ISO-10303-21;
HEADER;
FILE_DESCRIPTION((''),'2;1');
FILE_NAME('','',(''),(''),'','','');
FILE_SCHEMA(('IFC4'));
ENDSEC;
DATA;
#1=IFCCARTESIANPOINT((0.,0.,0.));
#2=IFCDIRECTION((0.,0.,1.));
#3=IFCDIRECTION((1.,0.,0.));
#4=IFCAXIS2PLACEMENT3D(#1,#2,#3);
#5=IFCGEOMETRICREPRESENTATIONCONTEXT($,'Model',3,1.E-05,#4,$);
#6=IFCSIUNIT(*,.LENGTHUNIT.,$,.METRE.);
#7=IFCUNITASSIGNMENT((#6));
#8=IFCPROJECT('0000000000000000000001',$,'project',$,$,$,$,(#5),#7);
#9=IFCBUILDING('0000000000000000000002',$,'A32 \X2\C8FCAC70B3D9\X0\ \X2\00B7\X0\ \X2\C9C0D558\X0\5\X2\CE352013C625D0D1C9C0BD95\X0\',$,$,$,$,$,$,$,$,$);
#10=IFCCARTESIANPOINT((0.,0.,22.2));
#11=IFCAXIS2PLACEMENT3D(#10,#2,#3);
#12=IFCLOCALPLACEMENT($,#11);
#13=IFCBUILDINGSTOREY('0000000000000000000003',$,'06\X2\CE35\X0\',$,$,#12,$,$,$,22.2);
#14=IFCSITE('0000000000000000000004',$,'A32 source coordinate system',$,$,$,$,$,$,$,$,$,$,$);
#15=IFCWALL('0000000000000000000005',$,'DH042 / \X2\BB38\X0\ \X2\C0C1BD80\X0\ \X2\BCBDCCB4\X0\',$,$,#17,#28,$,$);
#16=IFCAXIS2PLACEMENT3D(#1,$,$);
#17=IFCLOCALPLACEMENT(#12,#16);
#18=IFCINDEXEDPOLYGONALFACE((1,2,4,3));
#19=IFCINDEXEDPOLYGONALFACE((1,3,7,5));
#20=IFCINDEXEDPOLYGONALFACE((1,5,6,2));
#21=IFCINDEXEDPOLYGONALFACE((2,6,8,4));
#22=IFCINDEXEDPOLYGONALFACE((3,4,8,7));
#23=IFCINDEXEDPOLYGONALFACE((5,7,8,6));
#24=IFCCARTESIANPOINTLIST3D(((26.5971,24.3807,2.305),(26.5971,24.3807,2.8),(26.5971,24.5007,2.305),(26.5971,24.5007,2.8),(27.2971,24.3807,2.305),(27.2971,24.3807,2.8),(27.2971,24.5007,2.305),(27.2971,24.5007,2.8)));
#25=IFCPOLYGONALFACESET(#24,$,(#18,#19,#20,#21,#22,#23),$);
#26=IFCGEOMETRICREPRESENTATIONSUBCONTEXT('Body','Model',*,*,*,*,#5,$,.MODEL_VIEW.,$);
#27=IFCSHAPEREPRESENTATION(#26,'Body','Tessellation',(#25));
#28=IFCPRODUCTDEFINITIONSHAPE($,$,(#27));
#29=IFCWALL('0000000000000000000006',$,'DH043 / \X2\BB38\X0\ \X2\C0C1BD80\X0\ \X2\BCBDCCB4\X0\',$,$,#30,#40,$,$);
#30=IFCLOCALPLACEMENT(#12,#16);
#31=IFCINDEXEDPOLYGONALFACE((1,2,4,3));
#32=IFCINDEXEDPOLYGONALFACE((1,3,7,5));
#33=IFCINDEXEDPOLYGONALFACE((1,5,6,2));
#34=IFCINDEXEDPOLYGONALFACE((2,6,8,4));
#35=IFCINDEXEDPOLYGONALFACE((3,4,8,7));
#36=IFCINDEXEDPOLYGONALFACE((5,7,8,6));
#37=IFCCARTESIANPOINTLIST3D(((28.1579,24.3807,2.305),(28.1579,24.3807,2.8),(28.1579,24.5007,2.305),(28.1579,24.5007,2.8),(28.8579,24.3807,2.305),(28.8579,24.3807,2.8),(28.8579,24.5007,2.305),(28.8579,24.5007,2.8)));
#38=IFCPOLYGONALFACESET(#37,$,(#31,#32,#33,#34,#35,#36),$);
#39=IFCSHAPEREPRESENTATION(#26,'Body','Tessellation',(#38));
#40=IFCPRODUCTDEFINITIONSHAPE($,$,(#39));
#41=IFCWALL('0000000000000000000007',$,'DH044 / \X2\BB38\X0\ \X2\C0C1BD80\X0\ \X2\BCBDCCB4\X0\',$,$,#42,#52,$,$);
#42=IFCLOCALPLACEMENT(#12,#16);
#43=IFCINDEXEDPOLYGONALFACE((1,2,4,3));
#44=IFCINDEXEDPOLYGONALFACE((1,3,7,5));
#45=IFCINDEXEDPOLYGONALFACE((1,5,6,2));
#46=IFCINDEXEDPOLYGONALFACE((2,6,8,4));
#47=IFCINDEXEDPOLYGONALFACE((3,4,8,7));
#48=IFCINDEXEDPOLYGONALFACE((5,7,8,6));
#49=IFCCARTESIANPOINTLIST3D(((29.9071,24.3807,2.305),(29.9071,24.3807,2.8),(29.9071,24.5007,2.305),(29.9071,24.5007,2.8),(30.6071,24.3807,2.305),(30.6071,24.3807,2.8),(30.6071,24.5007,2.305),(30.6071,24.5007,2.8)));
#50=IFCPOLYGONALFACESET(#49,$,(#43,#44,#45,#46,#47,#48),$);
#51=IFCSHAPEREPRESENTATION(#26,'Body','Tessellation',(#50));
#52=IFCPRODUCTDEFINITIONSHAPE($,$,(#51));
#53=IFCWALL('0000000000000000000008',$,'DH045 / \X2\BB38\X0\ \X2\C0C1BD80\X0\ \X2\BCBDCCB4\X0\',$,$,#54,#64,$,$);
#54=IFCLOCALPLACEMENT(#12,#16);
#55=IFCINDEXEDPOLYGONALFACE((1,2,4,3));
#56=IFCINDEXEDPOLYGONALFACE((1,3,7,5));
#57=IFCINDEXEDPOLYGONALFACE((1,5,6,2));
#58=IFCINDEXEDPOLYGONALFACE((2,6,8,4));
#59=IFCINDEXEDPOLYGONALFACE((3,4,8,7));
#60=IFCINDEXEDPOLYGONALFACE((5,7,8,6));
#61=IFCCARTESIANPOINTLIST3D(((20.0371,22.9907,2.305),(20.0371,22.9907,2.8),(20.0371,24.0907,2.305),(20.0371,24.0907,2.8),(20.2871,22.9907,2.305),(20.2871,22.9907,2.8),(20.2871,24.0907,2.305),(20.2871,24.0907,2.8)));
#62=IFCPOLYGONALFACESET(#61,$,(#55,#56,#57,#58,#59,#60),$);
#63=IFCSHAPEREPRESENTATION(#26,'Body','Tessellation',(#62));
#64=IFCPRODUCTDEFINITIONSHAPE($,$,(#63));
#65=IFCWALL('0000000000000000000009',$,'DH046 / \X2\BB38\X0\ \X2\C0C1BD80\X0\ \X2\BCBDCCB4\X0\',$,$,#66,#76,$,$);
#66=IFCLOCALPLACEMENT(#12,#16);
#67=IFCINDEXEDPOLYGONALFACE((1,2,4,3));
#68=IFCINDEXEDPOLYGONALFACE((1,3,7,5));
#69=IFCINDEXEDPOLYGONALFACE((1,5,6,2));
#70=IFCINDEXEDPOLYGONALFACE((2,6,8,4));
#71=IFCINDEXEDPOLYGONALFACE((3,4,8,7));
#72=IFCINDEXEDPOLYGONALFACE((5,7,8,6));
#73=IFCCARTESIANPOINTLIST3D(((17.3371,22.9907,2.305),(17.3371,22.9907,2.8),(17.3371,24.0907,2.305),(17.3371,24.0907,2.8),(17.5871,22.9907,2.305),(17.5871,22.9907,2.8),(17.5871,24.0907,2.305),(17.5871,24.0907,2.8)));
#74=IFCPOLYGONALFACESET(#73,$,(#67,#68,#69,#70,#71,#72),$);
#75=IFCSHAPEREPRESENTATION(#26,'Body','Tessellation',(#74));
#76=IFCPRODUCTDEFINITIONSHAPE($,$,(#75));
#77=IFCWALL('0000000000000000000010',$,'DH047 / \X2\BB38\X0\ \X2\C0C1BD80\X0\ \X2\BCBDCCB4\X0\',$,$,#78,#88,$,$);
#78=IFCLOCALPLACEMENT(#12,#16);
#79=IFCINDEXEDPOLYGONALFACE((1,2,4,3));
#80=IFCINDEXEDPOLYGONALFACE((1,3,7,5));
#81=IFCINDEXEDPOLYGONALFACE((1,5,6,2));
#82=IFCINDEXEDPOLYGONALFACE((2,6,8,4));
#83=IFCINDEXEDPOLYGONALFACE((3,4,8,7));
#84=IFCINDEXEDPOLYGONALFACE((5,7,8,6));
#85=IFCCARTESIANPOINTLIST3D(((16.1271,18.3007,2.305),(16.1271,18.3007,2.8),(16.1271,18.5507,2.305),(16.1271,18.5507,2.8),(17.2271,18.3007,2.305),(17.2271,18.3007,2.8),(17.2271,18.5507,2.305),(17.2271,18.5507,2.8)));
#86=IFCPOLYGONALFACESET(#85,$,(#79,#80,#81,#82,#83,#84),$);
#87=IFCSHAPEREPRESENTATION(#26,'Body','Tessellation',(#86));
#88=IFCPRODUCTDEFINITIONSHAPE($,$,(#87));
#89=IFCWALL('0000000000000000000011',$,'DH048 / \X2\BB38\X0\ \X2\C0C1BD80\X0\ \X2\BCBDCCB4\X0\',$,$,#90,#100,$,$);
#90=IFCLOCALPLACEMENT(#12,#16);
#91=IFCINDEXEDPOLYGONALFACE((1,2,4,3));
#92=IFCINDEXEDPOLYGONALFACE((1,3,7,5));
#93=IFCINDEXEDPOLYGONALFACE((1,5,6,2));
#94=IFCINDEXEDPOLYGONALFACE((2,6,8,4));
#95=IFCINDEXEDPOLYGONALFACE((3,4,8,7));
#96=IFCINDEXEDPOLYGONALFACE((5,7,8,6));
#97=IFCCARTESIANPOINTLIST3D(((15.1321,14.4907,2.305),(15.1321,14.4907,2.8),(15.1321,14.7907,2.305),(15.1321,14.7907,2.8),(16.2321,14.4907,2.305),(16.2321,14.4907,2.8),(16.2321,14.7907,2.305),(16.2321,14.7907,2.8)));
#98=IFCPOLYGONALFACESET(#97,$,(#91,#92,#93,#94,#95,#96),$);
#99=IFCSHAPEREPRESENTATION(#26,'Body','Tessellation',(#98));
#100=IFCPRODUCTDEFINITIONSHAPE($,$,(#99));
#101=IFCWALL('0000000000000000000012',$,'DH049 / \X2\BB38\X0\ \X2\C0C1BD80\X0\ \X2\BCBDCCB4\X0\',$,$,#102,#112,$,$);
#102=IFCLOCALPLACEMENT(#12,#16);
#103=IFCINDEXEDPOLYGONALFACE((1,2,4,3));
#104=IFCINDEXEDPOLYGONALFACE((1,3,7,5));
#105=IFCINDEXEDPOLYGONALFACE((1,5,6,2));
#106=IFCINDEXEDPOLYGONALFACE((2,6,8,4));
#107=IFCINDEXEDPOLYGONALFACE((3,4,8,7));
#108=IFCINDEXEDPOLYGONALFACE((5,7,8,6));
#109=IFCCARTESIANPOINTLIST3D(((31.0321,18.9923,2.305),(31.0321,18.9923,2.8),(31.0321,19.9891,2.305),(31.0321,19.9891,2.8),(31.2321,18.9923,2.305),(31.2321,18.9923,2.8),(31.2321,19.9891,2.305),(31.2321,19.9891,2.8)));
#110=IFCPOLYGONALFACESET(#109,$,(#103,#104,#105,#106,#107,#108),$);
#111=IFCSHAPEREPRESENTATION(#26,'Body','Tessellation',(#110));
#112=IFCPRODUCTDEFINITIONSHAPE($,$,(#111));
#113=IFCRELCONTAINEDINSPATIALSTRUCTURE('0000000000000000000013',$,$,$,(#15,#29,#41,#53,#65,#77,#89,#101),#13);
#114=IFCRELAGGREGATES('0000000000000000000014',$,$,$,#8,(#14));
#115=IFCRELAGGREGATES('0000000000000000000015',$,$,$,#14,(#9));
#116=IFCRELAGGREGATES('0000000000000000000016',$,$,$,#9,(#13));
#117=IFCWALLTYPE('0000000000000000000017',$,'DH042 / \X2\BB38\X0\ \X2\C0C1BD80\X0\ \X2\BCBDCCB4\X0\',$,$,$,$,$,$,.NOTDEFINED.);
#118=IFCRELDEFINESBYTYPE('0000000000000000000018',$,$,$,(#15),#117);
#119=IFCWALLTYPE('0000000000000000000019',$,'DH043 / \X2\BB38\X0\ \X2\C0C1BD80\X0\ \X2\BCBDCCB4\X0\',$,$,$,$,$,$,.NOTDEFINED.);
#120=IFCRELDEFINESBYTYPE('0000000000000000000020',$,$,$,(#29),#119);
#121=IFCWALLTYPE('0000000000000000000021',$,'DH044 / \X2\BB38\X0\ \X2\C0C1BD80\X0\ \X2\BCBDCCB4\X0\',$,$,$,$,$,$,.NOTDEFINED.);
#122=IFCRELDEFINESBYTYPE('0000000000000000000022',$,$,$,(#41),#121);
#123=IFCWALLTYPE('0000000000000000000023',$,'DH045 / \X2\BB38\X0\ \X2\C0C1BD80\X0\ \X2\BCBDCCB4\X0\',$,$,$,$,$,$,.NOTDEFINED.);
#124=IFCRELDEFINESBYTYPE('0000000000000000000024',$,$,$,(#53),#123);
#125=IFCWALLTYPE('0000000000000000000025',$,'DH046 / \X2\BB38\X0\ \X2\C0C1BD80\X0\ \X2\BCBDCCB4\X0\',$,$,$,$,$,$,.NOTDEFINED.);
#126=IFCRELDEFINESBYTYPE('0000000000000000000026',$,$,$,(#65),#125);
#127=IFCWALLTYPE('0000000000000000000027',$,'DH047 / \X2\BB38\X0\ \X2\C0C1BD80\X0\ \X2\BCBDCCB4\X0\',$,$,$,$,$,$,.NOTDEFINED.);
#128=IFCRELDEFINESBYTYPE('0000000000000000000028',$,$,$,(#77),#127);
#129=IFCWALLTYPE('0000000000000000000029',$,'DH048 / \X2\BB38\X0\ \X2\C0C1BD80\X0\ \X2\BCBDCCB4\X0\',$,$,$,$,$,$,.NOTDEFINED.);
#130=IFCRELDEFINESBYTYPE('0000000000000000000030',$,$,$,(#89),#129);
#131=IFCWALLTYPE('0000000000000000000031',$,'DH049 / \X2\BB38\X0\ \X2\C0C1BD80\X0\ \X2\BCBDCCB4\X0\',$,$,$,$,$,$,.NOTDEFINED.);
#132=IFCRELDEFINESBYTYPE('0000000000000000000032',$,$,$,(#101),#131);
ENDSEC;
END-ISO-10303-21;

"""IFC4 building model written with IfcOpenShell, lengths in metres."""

from ifc_helpers import new_model, si_unit, frame, origin, origin_with_axes, place, context, subcontext, project, spatial, polyline, outline, extrude, source, transform, mapped, type_object, type_shapes, element, save


model = new_model("IFC4")

# Units and contexts
model_context = context("Model", 3, precision=1e-05, world=origin_with_axes())
body_context = subcontext(model_context, "Body", "Model", "MODEL_VIEW")
ifc_project = project(units=[si_unit("LENGTHUNIT", "METRE")], contexts=[model_context])

# Site, building, storey
site = spatial("IfcSite", under=ifc_project, Name="A32 source coordinate system")
building = spatial("IfcBuilding", under=site, Name="A32 주거동 · 지하5층–옥탑지붕")
storey_placement = place(None, frame((0.0, 0.0, 22.2), z_axis=(0.0, 0.0, 1.0), x_axis=(1.0, 0.0, 0.0)))
storey = spatial("IfcBuildingStorey", under=building, at=storey_placement, Name="06층", Elevation=22.2)

# Walls
wall_type_1 = type_object("IfcWallType", Name="DH042 / 문 상부 벽체", PredefinedType="NOTDEFINED")
shared_shape_1 = source(origin(), body_context, "Body", "SweptSolid", [
    extrude(outline(polyline([(27.2971, 24.3807), (26.5971, 24.3807), (26.5971, 24.5007), (27.2971, 24.5007), (27.2971, 24.3807)])), frame((0.0, 0.0, 2.305)), (0.0, 0.0, 1.0), 0.495),
])
type_shapes(wall_type_1, [shared_shape_1])
wall_1_placement = place(storey_placement, origin_with_axes())
element("IfcWall", 1, at=wall_1_placement, inside=storey, type_object=wall_type_1, Name="DH042 / 문 상부 벽체", context=body_context, shape_type="MappedRepresentation", body=[
    mapped(shared_shape_1, transform((0.0, 0.0, 0.0), scale=1.0)),
])
wall_type_2 = type_object("IfcWallType", Name="DH043 / 문 상부 벽체", PredefinedType="NOTDEFINED")
shared_shape_2 = source(origin(), body_context, "Body", "SweptSolid", [
    extrude(outline(polyline([(28.8579, 24.3807), (28.1579, 24.3807), (28.1579, 24.5007), (28.8579, 24.5007), (28.8579, 24.3807)])), frame((0.0, 0.0, 2.305)), (0.0, 0.0, 1.0), 0.495),
])
type_shapes(wall_type_2, [shared_shape_2])
wall_2_placement = place(storey_placement, origin_with_axes())
element("IfcWall", 2, at=wall_2_placement, inside=storey, type_object=wall_type_2, Name="DH043 / 문 상부 벽체", context=body_context, shape_type="MappedRepresentation", body=[
    mapped(shared_shape_2, transform((0.0, 0.0, 0.0), scale=1.0)),
])
wall_type_3 = type_object("IfcWallType", Name="DH044 / 문 상부 벽체", PredefinedType="NOTDEFINED")
shared_shape_3 = source(origin(), body_context, "Body", "SweptSolid", [
    extrude(outline(polyline([(30.6071, 24.3807), (29.9071, 24.3807), (29.9071, 24.5007), (30.6071, 24.5007), (30.6071, 24.3807)])), frame((0.0, 0.0, 2.305)), (0.0, 0.0, 1.0), 0.495),
])
type_shapes(wall_type_3, [shared_shape_3])
wall_3_placement = place(storey_placement, origin_with_axes())
element("IfcWall", 3, at=wall_3_placement, inside=storey, type_object=wall_type_3, Name="DH044 / 문 상부 벽체", context=body_context, shape_type="MappedRepresentation", body=[
    mapped(shared_shape_3, transform((0.0, 0.0, 0.0), scale=1.0)),
])
wall_type_4 = type_object("IfcWallType", Name="DH045 / 문 상부 벽체", PredefinedType="NOTDEFINED")
shared_shape_4 = source(origin(), body_context, "Body", "SweptSolid", [
    extrude(outline(polyline([(20.2871, 22.9907), (20.0371, 22.9907), (20.0371, 24.0907), (20.2871, 24.0907), (20.2871, 22.9907)])), frame((0.0, 0.0, 2.305)), (0.0, 0.0, 1.0), 0.495),
])
type_shapes(wall_type_4, [shared_shape_4])
wall_4_placement = place(storey_placement, origin_with_axes())
element("IfcWall", 4, at=wall_4_placement, inside=storey, type_object=wall_type_4, Name="DH045 / 문 상부 벽체", context=body_context, shape_type="MappedRepresentation", body=[
    mapped(shared_shape_4, transform((0.0, 0.0, 0.0), scale=1.0)),
])
wall_type_5 = type_object("IfcWallType", Name="DH046 / 문 상부 벽체", PredefinedType="NOTDEFINED")
shared_shape_5 = source(origin(), body_context, "Body", "SweptSolid", [
    extrude(outline(polyline([(17.5871, 22.9907), (17.3371, 22.9907), (17.3371, 24.0907), (17.5871, 24.0907), (17.5871, 22.9907)])), frame((0.0, 0.0, 2.305)), (0.0, 0.0, 1.0), 0.495),
])
type_shapes(wall_type_5, [shared_shape_5])
wall_5_placement = place(storey_placement, origin_with_axes())
element("IfcWall", 5, at=wall_5_placement, inside=storey, type_object=wall_type_5, Name="DH046 / 문 상부 벽체", context=body_context, shape_type="MappedRepresentation", body=[
    mapped(shared_shape_5, transform((0.0, 0.0, 0.0), scale=1.0)),
])
wall_type_6 = type_object("IfcWallType", Name="DH047 / 문 상부 벽체", PredefinedType="NOTDEFINED")
shared_shape_6 = source(origin(), body_context, "Body", "SweptSolid", [
    extrude(outline(polyline([(17.2271, 18.3007), (16.1271, 18.3007), (16.1271, 18.5507), (17.2271, 18.5507), (17.2271, 18.3007)])), frame((0.0, 0.0, 2.305)), (0.0, 0.0, 1.0), 0.495),
])
type_shapes(wall_type_6, [shared_shape_6])
wall_6_placement = place(storey_placement, origin_with_axes())
element("IfcWall", 6, at=wall_6_placement, inside=storey, type_object=wall_type_6, Name="DH047 / 문 상부 벽체", context=body_context, shape_type="MappedRepresentation", body=[
    mapped(shared_shape_6, transform((0.0, 0.0, 0.0), scale=1.0)),
])
wall_type_7 = type_object("IfcWallType", Name="DH048 / 문 상부 벽체", PredefinedType="NOTDEFINED")
shared_shape_7 = source(origin(), body_context, "Body", "SweptSolid", [
    extrude(outline(polyline([(15.1321, 14.7907), (16.2321, 14.7907), (16.2321, 14.4907), (15.1321, 14.4907), (15.1321, 14.7907)])), frame((0.0, 0.0, 2.305)), (0.0, 0.0, 1.0), 0.495),
])
type_shapes(wall_type_7, [shared_shape_7])
wall_7_placement = place(storey_placement, origin_with_axes())
element("IfcWall", 7, at=wall_7_placement, inside=storey, type_object=wall_type_7, Name="DH048 / 문 상부 벽체", context=body_context, shape_type="MappedRepresentation", body=[
    mapped(shared_shape_7, transform((0.0, 0.0, 0.0), scale=1.0)),
])
wall_type_8 = type_object("IfcWallType", Name="DH049 / 문 상부 벽체", PredefinedType="NOTDEFINED")
shared_shape_8 = source(origin(), body_context, "Body", "SweptSolid", [
    extrude(outline(polyline([(31.2321, 18.9923), (31.0321, 18.9923), (31.0321, 19.9891), (31.2321, 19.9891), (31.2321, 18.9923)])), frame((0.0, 0.0, 2.305)), (0.0, 0.0, 1.0), 0.495),
])
type_shapes(wall_type_8, [shared_shape_8])
wall_8_placement = place(storey_placement, origin_with_axes())
element("IfcWall", 8, at=wall_8_placement, inside=storey, type_object=wall_type_8, Name="DH049 / 문 상부 벽체", context=body_context, shape_type="MappedRepresentation", body=[
    mapped(shared_shape_8, transform((0.0, 0.0, 0.0), scale=1.0)),
])

save(model, "model.ifc")
